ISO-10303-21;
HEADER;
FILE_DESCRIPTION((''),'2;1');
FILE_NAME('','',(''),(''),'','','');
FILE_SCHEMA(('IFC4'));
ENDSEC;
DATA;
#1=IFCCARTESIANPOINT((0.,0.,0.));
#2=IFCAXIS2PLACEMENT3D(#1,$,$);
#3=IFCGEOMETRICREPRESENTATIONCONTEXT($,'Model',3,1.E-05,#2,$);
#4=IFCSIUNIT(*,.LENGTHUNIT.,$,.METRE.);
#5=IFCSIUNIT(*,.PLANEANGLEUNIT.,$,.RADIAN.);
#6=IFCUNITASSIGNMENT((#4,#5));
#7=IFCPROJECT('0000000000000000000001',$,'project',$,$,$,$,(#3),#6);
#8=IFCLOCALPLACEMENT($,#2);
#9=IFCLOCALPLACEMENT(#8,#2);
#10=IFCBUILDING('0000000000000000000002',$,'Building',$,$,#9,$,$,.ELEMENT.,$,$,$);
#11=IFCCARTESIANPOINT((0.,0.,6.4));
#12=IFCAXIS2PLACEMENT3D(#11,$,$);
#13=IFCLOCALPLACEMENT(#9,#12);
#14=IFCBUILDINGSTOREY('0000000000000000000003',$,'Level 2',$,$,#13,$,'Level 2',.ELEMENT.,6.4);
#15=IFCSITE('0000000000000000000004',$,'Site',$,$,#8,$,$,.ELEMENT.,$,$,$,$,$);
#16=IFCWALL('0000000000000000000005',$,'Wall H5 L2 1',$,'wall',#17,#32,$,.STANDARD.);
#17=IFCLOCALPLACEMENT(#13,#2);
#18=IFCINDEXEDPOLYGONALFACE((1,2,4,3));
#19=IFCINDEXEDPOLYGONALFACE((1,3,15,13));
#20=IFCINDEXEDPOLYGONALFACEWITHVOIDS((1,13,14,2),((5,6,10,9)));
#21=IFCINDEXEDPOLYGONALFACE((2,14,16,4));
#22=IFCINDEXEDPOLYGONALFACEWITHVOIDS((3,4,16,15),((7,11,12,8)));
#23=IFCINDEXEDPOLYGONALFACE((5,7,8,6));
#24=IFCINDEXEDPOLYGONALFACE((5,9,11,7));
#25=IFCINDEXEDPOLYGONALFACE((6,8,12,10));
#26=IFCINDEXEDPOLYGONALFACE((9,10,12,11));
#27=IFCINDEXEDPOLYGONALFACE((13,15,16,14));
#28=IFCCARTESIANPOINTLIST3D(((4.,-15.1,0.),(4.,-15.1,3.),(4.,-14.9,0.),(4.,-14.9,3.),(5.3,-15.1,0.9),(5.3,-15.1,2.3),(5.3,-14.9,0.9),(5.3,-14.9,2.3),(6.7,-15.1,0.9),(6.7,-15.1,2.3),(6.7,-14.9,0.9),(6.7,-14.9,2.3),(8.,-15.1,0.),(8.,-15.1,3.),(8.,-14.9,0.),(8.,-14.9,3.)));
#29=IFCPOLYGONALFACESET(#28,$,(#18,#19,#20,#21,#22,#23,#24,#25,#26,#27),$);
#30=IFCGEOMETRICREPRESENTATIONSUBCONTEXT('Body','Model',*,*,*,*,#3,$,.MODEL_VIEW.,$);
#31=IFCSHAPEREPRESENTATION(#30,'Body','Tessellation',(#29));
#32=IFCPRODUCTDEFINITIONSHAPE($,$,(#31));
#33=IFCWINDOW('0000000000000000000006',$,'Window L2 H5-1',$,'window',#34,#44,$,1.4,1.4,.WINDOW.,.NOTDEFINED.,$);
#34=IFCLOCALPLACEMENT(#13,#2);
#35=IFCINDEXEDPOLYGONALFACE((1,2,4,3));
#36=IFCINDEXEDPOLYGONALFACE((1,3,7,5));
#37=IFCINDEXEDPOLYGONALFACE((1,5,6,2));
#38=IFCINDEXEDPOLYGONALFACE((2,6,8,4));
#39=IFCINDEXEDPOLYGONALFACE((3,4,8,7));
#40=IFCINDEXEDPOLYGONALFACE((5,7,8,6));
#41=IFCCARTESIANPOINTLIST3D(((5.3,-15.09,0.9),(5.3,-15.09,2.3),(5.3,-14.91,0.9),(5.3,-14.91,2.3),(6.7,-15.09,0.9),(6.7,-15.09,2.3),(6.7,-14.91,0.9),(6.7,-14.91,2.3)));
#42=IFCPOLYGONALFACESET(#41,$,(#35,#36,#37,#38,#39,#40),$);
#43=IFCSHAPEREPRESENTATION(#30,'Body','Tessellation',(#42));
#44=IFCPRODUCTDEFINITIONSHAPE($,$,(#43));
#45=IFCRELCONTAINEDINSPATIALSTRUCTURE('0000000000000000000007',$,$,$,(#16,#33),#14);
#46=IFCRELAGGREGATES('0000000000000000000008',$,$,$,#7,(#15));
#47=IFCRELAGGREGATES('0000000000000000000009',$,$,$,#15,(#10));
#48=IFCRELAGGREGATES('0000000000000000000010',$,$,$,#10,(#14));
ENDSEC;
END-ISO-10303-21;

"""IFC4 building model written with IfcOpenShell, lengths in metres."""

from ifc_helpers import new_model, si_unit, frame, frame_2d, origin, origin_2d, place, context, subcontext, project, spatial, rectangle, extrude, element, fill, save


model = new_model("IFC4")

# Units and contexts
model_context = context("Model", 3, precision=1e-05, world=origin())
body_context = subcontext(model_context, "Body", "Model", "MODEL_VIEW")
ifc_project = project(units=[si_unit("LENGTHUNIT", "METRE"), si_unit("PLANEANGLEUNIT", "RADIAN")], contexts=[model_context])

# Site, building, storey
site_placement = place(None, origin())
site = spatial("IfcSite", under=ifc_project, at=site_placement, Name="Site", CompositionType="ELEMENT")
building_placement = place(site_placement, origin())
building = spatial("IfcBuilding", under=site, at=building_placement, Name="Building", CompositionType="ELEMENT")
storey_placement = place(building_placement, frame((0.0, 0.0, 6.4)))
storey = spatial("IfcBuildingStorey", under=building, at=storey_placement, Name="Level 2", LongName="Level 2", CompositionType="ELEMENT", Elevation=6.4)

# Wall, opening, window
wall_1_placement = place(storey_placement, frame((4.0, -15.0, 0.0), z_axis=(0.0, 0.0, 1.0), x_axis=(1.0, 0.0, 0.0)))
wall_1 = element("IfcWall", 1, at=wall_1_placement, inside=storey, Name="Wall H5 L2 1", ObjectType="wall", PredefinedType="STANDARD", context=body_context, shape_type="SweptSolid", body=[
    extrude(rectangle(XDim=4.0, YDim=0.2, at=frame_2d((2.0, 0.0))), origin(), (0.0, 0.0, 1.0), 3.0),
])
opening_1_placement = place(storey_placement, frame((6.0, -15.0, 0.9), z_axis=(0.0, 0.0, 1.0), x_axis=(1.0, 0.0, 0.0)))
opening_1 = element("IfcOpeningElement", 2, at=opening_1_placement, cuts=wall_1, ObjectType="Opening", PredefinedType="OPENING", context=body_context, shape_type="SweptSolid", body=[
    extrude(rectangle(XDim=1.4, YDim=0.22, at=origin_2d()), origin(), (0.0, 0.0, 1.0), 1.4),
])
window_1_placement = place(storey_placement, frame((6.0, -15.0, 0.9), z_axis=(0.0, 0.0, 1.0), x_axis=(1.0, 0.0, 0.0)))
window_1 = element("IfcWindow", 3, at=window_1_placement, inside=storey, Name="Window L2 H5-1", ObjectType="window", OverallHeight=1.4, OverallWidth=1.4, PartitioningType="NOTDEFINED", PredefinedType="WINDOW", context=body_context, shape_type="SweptSolid", body=[
    extrude(rectangle(XDim=1.4, YDim=0.18, at=origin_2d()), origin(), (0.0, 0.0, 1.0), 1.4),
])
fill(opening_1, window_1)

save(model, "model.ifc")
